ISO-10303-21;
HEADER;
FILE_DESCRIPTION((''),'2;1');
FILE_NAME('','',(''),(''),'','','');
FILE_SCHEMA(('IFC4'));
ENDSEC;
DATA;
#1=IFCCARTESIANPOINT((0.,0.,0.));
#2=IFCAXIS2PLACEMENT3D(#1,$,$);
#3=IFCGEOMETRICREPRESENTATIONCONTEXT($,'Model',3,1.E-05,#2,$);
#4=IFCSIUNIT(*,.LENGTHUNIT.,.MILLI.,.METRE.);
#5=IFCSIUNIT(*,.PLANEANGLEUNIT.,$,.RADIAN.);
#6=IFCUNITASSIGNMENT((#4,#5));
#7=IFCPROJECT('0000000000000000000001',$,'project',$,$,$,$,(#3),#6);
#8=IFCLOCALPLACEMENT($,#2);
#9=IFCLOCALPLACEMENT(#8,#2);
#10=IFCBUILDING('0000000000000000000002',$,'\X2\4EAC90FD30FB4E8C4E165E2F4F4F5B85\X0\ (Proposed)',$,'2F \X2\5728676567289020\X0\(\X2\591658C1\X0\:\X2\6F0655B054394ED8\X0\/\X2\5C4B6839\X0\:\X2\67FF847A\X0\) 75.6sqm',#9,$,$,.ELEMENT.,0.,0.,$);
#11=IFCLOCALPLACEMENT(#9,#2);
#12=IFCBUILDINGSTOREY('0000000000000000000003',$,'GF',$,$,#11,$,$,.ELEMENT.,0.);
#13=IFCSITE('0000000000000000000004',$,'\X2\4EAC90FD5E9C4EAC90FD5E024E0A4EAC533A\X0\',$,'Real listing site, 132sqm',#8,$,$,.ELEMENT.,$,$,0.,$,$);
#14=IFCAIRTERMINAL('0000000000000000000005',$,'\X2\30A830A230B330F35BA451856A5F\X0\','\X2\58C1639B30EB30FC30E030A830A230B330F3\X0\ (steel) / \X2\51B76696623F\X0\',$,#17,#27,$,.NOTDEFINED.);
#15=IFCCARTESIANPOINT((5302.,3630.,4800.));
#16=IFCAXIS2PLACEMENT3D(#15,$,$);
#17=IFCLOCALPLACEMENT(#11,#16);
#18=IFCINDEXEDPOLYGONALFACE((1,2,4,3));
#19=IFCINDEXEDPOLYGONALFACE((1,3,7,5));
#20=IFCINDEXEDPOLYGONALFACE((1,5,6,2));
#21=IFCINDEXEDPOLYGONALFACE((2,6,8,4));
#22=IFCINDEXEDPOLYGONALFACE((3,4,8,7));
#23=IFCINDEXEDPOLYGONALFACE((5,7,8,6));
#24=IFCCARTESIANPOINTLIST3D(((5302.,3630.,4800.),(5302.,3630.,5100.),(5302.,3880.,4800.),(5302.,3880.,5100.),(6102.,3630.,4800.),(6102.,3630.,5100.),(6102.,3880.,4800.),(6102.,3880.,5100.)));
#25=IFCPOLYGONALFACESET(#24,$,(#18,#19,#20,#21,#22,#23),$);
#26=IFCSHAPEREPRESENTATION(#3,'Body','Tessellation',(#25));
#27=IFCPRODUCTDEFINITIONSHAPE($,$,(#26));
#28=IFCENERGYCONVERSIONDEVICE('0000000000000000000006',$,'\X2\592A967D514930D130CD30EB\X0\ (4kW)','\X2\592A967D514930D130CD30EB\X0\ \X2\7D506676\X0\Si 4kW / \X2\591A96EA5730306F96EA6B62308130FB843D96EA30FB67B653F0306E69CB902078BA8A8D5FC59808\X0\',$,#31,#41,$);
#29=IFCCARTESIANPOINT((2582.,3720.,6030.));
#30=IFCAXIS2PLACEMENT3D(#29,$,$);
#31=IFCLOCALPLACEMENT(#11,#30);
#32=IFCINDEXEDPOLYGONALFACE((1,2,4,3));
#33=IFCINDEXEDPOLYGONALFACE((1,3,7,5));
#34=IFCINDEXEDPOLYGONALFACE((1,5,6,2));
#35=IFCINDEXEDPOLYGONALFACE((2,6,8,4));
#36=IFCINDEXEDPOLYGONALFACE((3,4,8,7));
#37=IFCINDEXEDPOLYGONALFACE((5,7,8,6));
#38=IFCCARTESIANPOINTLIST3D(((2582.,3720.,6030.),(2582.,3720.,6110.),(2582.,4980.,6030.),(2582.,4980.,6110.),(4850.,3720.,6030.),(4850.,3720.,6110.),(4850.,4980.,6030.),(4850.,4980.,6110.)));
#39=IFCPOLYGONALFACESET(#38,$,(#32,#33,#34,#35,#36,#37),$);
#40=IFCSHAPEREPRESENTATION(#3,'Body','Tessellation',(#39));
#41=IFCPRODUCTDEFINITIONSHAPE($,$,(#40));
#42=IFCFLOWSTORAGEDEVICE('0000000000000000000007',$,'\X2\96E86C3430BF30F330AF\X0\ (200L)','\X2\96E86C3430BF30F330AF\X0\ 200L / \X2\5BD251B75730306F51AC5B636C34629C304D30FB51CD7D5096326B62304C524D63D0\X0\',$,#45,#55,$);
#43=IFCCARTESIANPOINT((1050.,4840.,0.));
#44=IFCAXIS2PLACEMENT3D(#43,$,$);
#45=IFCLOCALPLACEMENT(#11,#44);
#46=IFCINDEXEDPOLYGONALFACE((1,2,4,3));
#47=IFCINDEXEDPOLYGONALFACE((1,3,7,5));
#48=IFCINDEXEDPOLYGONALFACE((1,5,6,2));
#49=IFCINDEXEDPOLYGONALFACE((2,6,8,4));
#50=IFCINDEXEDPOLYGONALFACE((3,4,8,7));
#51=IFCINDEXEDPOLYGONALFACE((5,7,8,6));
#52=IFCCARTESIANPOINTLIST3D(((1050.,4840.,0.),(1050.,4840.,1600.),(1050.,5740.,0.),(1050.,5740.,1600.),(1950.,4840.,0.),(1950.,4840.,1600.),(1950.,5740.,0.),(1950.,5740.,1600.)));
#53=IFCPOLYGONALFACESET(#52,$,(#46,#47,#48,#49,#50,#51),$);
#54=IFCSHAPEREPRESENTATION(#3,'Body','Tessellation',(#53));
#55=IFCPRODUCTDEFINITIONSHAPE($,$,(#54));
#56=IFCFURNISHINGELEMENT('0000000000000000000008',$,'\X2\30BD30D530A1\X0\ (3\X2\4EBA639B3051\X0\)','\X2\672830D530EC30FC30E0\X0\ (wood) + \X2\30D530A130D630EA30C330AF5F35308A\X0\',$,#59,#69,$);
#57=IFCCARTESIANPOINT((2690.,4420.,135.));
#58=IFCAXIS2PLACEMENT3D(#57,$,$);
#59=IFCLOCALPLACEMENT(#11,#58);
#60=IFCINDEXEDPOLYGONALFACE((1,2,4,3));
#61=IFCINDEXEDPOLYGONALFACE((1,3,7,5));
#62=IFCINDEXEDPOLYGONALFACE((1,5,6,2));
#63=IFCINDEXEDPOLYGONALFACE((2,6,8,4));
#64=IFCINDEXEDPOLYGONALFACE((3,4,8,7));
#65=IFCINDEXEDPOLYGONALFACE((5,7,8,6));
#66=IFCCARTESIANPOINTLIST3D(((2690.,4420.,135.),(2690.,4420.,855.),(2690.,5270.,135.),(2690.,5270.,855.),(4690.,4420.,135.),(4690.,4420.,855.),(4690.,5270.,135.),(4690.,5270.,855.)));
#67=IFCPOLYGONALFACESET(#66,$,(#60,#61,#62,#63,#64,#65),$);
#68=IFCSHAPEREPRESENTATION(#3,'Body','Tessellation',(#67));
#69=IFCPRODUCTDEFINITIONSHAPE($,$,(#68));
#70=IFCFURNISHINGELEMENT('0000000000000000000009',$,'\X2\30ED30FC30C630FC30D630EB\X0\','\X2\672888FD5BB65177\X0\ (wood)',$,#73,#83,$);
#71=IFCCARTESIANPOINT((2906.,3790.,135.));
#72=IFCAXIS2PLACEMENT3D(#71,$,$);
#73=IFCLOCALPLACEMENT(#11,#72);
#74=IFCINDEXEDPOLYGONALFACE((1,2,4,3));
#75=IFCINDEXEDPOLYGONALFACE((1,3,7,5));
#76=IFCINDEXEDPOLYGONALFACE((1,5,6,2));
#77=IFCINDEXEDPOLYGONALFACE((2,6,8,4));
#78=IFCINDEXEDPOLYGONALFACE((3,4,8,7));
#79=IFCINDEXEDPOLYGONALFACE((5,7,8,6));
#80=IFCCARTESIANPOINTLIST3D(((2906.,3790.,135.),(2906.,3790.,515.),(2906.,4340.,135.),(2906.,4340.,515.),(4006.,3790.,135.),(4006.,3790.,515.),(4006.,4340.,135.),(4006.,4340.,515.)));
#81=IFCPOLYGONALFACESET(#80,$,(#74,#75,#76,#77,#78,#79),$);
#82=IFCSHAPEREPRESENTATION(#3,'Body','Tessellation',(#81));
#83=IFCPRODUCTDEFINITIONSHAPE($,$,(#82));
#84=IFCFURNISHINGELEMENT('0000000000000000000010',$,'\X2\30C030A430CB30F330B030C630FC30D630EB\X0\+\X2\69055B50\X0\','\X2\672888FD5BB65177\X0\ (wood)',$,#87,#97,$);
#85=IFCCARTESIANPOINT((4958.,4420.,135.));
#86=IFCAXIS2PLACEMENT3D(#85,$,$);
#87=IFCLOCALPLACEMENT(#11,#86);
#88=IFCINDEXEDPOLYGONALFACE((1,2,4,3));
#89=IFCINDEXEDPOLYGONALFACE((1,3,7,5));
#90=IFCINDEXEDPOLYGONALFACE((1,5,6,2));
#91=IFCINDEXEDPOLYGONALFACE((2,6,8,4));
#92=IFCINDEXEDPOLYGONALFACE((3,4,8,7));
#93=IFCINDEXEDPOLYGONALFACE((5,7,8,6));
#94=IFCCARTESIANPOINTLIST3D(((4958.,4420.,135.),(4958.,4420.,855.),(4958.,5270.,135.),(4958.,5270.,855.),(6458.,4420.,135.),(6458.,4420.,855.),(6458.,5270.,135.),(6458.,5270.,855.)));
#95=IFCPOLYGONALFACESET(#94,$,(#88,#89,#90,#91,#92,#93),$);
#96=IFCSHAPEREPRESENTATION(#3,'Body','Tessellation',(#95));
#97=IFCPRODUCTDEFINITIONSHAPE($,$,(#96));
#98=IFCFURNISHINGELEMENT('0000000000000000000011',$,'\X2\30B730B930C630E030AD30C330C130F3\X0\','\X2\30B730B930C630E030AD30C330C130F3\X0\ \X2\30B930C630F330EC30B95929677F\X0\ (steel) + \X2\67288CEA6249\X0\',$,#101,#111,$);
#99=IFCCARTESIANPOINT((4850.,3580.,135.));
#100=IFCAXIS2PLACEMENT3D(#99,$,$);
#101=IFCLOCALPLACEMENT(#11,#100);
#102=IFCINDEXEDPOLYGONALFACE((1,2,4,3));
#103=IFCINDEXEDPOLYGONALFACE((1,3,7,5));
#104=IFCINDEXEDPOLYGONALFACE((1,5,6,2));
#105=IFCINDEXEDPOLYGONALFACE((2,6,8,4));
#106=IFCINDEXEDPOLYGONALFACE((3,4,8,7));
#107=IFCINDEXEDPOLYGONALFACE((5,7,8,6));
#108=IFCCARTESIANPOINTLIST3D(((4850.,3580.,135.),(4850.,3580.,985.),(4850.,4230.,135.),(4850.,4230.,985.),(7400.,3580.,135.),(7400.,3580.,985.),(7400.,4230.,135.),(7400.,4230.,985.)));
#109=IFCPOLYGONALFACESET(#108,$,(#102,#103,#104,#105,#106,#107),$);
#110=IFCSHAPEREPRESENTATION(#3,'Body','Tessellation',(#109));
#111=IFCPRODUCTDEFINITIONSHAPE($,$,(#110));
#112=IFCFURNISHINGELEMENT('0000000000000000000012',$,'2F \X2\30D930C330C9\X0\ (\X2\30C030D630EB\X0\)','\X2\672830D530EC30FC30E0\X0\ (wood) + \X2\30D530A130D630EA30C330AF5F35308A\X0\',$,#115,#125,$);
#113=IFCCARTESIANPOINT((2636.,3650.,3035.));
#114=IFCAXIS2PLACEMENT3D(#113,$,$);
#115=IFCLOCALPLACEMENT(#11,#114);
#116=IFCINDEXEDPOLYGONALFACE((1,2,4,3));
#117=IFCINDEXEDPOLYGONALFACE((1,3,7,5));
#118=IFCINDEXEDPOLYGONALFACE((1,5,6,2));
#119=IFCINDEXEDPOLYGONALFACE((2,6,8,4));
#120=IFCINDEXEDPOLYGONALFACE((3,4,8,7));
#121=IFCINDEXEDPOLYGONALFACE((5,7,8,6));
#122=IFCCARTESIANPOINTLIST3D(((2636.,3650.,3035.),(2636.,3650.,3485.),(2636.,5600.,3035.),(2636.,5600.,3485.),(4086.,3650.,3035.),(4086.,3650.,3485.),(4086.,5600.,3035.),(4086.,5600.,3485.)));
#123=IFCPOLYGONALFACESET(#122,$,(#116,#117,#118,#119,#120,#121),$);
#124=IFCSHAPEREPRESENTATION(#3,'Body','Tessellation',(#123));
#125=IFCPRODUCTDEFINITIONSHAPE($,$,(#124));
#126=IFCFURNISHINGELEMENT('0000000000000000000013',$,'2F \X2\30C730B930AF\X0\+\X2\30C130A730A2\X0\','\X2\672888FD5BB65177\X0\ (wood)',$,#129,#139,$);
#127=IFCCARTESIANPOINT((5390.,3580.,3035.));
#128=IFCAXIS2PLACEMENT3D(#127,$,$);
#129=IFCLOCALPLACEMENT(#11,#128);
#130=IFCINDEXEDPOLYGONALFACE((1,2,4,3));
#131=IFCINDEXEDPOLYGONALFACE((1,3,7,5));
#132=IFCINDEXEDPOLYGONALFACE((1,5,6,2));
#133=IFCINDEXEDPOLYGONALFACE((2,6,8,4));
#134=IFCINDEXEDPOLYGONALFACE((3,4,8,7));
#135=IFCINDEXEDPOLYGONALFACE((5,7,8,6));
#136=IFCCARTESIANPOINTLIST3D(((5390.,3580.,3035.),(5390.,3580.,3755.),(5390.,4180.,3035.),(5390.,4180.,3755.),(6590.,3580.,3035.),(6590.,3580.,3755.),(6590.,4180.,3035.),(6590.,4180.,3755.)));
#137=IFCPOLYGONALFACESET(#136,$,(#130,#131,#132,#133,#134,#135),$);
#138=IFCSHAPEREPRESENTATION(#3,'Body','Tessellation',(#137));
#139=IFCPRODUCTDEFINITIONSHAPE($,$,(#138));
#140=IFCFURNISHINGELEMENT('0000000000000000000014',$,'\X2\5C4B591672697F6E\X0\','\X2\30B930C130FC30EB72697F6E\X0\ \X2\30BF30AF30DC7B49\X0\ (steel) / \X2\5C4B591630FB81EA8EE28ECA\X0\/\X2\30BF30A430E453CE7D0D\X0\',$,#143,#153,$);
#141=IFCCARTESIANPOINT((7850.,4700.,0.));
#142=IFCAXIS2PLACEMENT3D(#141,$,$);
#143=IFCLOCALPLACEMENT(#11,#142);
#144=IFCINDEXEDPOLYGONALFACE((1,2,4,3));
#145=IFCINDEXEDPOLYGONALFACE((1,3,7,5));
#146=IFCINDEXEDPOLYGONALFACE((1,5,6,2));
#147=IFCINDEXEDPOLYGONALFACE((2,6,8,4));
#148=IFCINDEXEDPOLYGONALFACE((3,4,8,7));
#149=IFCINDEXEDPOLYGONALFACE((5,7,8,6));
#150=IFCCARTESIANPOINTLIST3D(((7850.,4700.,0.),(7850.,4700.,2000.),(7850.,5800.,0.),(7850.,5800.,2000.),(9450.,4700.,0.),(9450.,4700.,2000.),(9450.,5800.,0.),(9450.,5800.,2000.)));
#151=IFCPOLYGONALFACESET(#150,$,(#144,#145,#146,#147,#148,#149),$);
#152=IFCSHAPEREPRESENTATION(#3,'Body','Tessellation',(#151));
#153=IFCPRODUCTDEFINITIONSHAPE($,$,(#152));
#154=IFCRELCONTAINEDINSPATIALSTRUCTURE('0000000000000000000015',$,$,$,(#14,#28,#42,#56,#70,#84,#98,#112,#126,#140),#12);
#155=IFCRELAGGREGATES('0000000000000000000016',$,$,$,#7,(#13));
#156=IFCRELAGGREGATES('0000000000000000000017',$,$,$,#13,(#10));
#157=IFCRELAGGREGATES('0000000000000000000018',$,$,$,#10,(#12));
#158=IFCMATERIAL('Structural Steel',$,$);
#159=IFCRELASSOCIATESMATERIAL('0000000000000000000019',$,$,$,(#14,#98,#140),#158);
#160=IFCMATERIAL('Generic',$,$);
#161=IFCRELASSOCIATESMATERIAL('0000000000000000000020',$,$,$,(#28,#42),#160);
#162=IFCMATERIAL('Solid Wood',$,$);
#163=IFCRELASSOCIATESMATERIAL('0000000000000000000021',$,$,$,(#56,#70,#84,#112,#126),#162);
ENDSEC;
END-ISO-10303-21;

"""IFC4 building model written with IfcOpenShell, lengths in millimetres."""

from ifc_helpers import new_model, si_unit, frame, frame_2d, origin, place, context, project, spatial, rectangle, extrude, material, element, save


model = new_model("IFC4")

# Units and contexts
model_context = context("Model", 3, precision=1e-05, world=origin())
ifc_project = project(units=[si_unit("LENGTHUNIT", "METRE", prefix="MILLI"), si_unit("PLANEANGLEUNIT", "RADIAN")], contexts=[model_context])

# Site, building, storey
site_placement = place(None, origin())
site = spatial("IfcSite", under=ifc_project, at=site_placement, Name="京都府京都市上京区", ObjectType="Real listing site, 132sqm", CompositionType="ELEMENT", RefElevation=0.0)
building_placement = place(site_placement, origin())
building = spatial("IfcBuilding", under=site, at=building_placement, Name="京都・二世帯住宅 (Proposed)", ObjectType="2F 在来木造(外壁:漆喰吹付/屋根:柿葺) 75.6sqm", CompositionType="ELEMENT", ElevationOfRefHeight=0.0, ElevationOfTerrain=0.0)
storey_placement = place(building_placement, origin())
storey = spatial("IfcBuildingStorey", under=building, at=storey_placement, Name="GF", CompositionType="ELEMENT", Elevation=0.0)

# Shared definitions
ifc_material_1 = material(Name="Solid Wood")

# Shared definitions
ifc_material_2 = material(Name="Generic")

# Shared definitions
ifc_material_3 = material(Name="Structural Steel")

# Air terminal
air_terminal_1_placement = place(storey_placement, frame((5302.0, 3630.0, 4800.0)))
element("IfcAirTerminal", 1, at=air_terminal_1_placement, inside=storey, material=ifc_material_3, Name="エアコン室内機", Description="壁掛ルームエアコン (steel) / 冷暖房", PredefinedType="NOTDEFINED", context=model_context, shape_type="SweptSolid", body=[
    extrude(rectangle(XDim=800.0, YDim=250.0, at=frame_2d((400.0, 125.0))), frame((5302.0, 3630.0, 4800.0)), (0.0, 0.0, 1.0), 300.0),
])

# Energy conversion device
energy_conversion_device_placement = place(storey_placement, frame((2582.0, 3720.0, 6030.0)))
element("IfcEnergyConversionDevice", 2, at=energy_conversion_device_placement, inside=storey, material=ifc_material_2, Name="太陽光パネル (4kW)", Description="太陽光パネル 結晶Si 4kW / 多雪地は雪止め・落雪・架台の構造確認必須", context=model_context, shape_type="SweptSolid", body=[
    extrude(rectangle(XDim=2268.0, YDim=1260.0, at=frame_2d((1134.0, 630.0))), frame((2582.0, 3720.0, 6030.0)), (0.0, 0.0, 1.0), 80.0),
])

# Flow storage device
flow_storage_device_placement = place(storey_placement, frame((1050.0, 4840.0, 0.0)))
element("IfcFlowStorageDevice", 3, at=flow_storage_device_placement, inside=storey, material=ifc_material_2, Name="雨水タンク (200L)", Description="雨水タンク 200L / 寒冷地は冬季水抜き・凍結防止が前提", context=model_context, shape_type="SweptSolid", body=[
    extrude(rectangle(XDim=900.0, YDim=900.0, at=frame_2d((450.0, 450.0))), frame((1050.0, 4840.0, 0.0)), (0.0, 0.0, 1.0), 1600.0),
])

# Furnishing elements
furnishing_1_placement = place(storey_placement, frame((2690.0, 4420.0, 135.0)))
element("IfcFurnishingElement", 4, at=furnishing_1_placement, inside=storey, material=ifc_material_1, Name="ソファ (3人掛け)", Description="木フレーム (wood) + ファブリック張り", context=model_context, shape_type="SweptSolid", body=[
    extrude(rectangle(XDim=2000.0, YDim=850.0, at=frame_2d((1000.0, 425.0))), frame((2690.0, 4420.0, 135.0)), (0.0, 0.0, 1.0), 720.0),
])
furnishing_2_placement = place(storey_placement, frame((2906.0, 3790.0, 135.0)))
element("IfcFurnishingElement", 5, at=furnishing_2_placement, inside=storey, material=ifc_material_1, Name="ローテーブル", Description="木製家具 (wood)", context=model_context, shape_type="SweptSolid", body=[
    extrude(rectangle(XDim=1100.0, YDim=550.0, at=frame_2d((550.0, 275.0))), frame((2906.0, 3790.0, 135.0)), (0.0, 0.0, 1.0), 380.0),
])
furnishing_3_placement = place(storey_placement, frame((4958.0, 4420.0, 135.0)))
element("IfcFurnishingElement", 6, at=furnishing_3_placement, inside=storey, material=ifc_material_1, Name="ダイニングテーブル+椅子", Description="木製家具 (wood)", context=model_context, shape_type="SweptSolid", body=[
    extrude(rectangle(XDim=1500.0, YDim=850.0, at=frame_2d((750.0, 425.0))), frame((4958.0, 4420.0, 135.0)), (0.0, 0.0, 1.0), 720.0),
])
furnishing_4_placement = place(storey_placement, frame((4850.0, 3580.0, 135.0)))
element("IfcFurnishingElement", 7, at=furnishing_4_placement, inside=storey, material=ifc_material_3, Name="システムキッチン", Description="システムキッチン ステンレス天板 (steel) + 木質扉", context=model_context, shape_type="SweptSolid", body=[
    extrude(rectangle(XDim=2550.0, YDim=650.0, at=frame_2d((1275.0, 325.0))), frame((4850.0, 3580.0, 135.0)), (0.0, 0.0, 1.0), 850.0),
])
furnishing_5_placement = place(storey_placement, frame((2636.0, 3650.0, 3035.0)))
element("IfcFurnishingElement", 8, at=furnishing_5_placement, inside=storey, material=ifc_material_1, Name="2F ベッド (ダブル)", Description="木フレーム (wood) + ファブリック張り", context=model_context, shape_type="SweptSolid", body=[
    extrude(rectangle(XDim=1450.0, YDim=1950.0, at=frame_2d((725.0, 975.0))), frame((2636.0, 3650.0, 3035.0)), (0.0, 0.0, 1.0), 450.0),
])
furnishing_6_placement = place(storey_placement, frame((5390.0, 3580.0, 3035.0)))
element("IfcFurnishingElement", 9, at=furnishing_6_placement, inside=storey, material=ifc_material_1, Name="2F デスク+チェア", Description="木製家具 (wood)", context=model_context, shape_type="SweptSolid", body=[
    extrude(rectangle(XDim=1200.0, YDim=600.0, at=frame_2d((600.0, 300.0))), frame((5390.0, 3580.0, 3035.0)), (0.0, 0.0, 1.0), 720.0),
])
furnishing_7_placement = place(storey_placement, frame((7850.0, 4700.0, 0.0)))
element("IfcFurnishingElement", 10, at=furnishing_7_placement, inside=storey, material=ifc_material_3, Name="屋外物置", Description="スチール物置 タクボ等 (steel) / 屋外・自転車/タイヤ収納", context=model_context, shape_type="SweptSolid", body=[
    extrude(rectangle(XDim=1600.0, YDim=1100.0, at=frame_2d((800.0, 550.0))), frame((7850.0, 4700.0, 0.0)), (0.0, 0.0, 1.0), 2000.0),
])

save(model, "model.ifc")
